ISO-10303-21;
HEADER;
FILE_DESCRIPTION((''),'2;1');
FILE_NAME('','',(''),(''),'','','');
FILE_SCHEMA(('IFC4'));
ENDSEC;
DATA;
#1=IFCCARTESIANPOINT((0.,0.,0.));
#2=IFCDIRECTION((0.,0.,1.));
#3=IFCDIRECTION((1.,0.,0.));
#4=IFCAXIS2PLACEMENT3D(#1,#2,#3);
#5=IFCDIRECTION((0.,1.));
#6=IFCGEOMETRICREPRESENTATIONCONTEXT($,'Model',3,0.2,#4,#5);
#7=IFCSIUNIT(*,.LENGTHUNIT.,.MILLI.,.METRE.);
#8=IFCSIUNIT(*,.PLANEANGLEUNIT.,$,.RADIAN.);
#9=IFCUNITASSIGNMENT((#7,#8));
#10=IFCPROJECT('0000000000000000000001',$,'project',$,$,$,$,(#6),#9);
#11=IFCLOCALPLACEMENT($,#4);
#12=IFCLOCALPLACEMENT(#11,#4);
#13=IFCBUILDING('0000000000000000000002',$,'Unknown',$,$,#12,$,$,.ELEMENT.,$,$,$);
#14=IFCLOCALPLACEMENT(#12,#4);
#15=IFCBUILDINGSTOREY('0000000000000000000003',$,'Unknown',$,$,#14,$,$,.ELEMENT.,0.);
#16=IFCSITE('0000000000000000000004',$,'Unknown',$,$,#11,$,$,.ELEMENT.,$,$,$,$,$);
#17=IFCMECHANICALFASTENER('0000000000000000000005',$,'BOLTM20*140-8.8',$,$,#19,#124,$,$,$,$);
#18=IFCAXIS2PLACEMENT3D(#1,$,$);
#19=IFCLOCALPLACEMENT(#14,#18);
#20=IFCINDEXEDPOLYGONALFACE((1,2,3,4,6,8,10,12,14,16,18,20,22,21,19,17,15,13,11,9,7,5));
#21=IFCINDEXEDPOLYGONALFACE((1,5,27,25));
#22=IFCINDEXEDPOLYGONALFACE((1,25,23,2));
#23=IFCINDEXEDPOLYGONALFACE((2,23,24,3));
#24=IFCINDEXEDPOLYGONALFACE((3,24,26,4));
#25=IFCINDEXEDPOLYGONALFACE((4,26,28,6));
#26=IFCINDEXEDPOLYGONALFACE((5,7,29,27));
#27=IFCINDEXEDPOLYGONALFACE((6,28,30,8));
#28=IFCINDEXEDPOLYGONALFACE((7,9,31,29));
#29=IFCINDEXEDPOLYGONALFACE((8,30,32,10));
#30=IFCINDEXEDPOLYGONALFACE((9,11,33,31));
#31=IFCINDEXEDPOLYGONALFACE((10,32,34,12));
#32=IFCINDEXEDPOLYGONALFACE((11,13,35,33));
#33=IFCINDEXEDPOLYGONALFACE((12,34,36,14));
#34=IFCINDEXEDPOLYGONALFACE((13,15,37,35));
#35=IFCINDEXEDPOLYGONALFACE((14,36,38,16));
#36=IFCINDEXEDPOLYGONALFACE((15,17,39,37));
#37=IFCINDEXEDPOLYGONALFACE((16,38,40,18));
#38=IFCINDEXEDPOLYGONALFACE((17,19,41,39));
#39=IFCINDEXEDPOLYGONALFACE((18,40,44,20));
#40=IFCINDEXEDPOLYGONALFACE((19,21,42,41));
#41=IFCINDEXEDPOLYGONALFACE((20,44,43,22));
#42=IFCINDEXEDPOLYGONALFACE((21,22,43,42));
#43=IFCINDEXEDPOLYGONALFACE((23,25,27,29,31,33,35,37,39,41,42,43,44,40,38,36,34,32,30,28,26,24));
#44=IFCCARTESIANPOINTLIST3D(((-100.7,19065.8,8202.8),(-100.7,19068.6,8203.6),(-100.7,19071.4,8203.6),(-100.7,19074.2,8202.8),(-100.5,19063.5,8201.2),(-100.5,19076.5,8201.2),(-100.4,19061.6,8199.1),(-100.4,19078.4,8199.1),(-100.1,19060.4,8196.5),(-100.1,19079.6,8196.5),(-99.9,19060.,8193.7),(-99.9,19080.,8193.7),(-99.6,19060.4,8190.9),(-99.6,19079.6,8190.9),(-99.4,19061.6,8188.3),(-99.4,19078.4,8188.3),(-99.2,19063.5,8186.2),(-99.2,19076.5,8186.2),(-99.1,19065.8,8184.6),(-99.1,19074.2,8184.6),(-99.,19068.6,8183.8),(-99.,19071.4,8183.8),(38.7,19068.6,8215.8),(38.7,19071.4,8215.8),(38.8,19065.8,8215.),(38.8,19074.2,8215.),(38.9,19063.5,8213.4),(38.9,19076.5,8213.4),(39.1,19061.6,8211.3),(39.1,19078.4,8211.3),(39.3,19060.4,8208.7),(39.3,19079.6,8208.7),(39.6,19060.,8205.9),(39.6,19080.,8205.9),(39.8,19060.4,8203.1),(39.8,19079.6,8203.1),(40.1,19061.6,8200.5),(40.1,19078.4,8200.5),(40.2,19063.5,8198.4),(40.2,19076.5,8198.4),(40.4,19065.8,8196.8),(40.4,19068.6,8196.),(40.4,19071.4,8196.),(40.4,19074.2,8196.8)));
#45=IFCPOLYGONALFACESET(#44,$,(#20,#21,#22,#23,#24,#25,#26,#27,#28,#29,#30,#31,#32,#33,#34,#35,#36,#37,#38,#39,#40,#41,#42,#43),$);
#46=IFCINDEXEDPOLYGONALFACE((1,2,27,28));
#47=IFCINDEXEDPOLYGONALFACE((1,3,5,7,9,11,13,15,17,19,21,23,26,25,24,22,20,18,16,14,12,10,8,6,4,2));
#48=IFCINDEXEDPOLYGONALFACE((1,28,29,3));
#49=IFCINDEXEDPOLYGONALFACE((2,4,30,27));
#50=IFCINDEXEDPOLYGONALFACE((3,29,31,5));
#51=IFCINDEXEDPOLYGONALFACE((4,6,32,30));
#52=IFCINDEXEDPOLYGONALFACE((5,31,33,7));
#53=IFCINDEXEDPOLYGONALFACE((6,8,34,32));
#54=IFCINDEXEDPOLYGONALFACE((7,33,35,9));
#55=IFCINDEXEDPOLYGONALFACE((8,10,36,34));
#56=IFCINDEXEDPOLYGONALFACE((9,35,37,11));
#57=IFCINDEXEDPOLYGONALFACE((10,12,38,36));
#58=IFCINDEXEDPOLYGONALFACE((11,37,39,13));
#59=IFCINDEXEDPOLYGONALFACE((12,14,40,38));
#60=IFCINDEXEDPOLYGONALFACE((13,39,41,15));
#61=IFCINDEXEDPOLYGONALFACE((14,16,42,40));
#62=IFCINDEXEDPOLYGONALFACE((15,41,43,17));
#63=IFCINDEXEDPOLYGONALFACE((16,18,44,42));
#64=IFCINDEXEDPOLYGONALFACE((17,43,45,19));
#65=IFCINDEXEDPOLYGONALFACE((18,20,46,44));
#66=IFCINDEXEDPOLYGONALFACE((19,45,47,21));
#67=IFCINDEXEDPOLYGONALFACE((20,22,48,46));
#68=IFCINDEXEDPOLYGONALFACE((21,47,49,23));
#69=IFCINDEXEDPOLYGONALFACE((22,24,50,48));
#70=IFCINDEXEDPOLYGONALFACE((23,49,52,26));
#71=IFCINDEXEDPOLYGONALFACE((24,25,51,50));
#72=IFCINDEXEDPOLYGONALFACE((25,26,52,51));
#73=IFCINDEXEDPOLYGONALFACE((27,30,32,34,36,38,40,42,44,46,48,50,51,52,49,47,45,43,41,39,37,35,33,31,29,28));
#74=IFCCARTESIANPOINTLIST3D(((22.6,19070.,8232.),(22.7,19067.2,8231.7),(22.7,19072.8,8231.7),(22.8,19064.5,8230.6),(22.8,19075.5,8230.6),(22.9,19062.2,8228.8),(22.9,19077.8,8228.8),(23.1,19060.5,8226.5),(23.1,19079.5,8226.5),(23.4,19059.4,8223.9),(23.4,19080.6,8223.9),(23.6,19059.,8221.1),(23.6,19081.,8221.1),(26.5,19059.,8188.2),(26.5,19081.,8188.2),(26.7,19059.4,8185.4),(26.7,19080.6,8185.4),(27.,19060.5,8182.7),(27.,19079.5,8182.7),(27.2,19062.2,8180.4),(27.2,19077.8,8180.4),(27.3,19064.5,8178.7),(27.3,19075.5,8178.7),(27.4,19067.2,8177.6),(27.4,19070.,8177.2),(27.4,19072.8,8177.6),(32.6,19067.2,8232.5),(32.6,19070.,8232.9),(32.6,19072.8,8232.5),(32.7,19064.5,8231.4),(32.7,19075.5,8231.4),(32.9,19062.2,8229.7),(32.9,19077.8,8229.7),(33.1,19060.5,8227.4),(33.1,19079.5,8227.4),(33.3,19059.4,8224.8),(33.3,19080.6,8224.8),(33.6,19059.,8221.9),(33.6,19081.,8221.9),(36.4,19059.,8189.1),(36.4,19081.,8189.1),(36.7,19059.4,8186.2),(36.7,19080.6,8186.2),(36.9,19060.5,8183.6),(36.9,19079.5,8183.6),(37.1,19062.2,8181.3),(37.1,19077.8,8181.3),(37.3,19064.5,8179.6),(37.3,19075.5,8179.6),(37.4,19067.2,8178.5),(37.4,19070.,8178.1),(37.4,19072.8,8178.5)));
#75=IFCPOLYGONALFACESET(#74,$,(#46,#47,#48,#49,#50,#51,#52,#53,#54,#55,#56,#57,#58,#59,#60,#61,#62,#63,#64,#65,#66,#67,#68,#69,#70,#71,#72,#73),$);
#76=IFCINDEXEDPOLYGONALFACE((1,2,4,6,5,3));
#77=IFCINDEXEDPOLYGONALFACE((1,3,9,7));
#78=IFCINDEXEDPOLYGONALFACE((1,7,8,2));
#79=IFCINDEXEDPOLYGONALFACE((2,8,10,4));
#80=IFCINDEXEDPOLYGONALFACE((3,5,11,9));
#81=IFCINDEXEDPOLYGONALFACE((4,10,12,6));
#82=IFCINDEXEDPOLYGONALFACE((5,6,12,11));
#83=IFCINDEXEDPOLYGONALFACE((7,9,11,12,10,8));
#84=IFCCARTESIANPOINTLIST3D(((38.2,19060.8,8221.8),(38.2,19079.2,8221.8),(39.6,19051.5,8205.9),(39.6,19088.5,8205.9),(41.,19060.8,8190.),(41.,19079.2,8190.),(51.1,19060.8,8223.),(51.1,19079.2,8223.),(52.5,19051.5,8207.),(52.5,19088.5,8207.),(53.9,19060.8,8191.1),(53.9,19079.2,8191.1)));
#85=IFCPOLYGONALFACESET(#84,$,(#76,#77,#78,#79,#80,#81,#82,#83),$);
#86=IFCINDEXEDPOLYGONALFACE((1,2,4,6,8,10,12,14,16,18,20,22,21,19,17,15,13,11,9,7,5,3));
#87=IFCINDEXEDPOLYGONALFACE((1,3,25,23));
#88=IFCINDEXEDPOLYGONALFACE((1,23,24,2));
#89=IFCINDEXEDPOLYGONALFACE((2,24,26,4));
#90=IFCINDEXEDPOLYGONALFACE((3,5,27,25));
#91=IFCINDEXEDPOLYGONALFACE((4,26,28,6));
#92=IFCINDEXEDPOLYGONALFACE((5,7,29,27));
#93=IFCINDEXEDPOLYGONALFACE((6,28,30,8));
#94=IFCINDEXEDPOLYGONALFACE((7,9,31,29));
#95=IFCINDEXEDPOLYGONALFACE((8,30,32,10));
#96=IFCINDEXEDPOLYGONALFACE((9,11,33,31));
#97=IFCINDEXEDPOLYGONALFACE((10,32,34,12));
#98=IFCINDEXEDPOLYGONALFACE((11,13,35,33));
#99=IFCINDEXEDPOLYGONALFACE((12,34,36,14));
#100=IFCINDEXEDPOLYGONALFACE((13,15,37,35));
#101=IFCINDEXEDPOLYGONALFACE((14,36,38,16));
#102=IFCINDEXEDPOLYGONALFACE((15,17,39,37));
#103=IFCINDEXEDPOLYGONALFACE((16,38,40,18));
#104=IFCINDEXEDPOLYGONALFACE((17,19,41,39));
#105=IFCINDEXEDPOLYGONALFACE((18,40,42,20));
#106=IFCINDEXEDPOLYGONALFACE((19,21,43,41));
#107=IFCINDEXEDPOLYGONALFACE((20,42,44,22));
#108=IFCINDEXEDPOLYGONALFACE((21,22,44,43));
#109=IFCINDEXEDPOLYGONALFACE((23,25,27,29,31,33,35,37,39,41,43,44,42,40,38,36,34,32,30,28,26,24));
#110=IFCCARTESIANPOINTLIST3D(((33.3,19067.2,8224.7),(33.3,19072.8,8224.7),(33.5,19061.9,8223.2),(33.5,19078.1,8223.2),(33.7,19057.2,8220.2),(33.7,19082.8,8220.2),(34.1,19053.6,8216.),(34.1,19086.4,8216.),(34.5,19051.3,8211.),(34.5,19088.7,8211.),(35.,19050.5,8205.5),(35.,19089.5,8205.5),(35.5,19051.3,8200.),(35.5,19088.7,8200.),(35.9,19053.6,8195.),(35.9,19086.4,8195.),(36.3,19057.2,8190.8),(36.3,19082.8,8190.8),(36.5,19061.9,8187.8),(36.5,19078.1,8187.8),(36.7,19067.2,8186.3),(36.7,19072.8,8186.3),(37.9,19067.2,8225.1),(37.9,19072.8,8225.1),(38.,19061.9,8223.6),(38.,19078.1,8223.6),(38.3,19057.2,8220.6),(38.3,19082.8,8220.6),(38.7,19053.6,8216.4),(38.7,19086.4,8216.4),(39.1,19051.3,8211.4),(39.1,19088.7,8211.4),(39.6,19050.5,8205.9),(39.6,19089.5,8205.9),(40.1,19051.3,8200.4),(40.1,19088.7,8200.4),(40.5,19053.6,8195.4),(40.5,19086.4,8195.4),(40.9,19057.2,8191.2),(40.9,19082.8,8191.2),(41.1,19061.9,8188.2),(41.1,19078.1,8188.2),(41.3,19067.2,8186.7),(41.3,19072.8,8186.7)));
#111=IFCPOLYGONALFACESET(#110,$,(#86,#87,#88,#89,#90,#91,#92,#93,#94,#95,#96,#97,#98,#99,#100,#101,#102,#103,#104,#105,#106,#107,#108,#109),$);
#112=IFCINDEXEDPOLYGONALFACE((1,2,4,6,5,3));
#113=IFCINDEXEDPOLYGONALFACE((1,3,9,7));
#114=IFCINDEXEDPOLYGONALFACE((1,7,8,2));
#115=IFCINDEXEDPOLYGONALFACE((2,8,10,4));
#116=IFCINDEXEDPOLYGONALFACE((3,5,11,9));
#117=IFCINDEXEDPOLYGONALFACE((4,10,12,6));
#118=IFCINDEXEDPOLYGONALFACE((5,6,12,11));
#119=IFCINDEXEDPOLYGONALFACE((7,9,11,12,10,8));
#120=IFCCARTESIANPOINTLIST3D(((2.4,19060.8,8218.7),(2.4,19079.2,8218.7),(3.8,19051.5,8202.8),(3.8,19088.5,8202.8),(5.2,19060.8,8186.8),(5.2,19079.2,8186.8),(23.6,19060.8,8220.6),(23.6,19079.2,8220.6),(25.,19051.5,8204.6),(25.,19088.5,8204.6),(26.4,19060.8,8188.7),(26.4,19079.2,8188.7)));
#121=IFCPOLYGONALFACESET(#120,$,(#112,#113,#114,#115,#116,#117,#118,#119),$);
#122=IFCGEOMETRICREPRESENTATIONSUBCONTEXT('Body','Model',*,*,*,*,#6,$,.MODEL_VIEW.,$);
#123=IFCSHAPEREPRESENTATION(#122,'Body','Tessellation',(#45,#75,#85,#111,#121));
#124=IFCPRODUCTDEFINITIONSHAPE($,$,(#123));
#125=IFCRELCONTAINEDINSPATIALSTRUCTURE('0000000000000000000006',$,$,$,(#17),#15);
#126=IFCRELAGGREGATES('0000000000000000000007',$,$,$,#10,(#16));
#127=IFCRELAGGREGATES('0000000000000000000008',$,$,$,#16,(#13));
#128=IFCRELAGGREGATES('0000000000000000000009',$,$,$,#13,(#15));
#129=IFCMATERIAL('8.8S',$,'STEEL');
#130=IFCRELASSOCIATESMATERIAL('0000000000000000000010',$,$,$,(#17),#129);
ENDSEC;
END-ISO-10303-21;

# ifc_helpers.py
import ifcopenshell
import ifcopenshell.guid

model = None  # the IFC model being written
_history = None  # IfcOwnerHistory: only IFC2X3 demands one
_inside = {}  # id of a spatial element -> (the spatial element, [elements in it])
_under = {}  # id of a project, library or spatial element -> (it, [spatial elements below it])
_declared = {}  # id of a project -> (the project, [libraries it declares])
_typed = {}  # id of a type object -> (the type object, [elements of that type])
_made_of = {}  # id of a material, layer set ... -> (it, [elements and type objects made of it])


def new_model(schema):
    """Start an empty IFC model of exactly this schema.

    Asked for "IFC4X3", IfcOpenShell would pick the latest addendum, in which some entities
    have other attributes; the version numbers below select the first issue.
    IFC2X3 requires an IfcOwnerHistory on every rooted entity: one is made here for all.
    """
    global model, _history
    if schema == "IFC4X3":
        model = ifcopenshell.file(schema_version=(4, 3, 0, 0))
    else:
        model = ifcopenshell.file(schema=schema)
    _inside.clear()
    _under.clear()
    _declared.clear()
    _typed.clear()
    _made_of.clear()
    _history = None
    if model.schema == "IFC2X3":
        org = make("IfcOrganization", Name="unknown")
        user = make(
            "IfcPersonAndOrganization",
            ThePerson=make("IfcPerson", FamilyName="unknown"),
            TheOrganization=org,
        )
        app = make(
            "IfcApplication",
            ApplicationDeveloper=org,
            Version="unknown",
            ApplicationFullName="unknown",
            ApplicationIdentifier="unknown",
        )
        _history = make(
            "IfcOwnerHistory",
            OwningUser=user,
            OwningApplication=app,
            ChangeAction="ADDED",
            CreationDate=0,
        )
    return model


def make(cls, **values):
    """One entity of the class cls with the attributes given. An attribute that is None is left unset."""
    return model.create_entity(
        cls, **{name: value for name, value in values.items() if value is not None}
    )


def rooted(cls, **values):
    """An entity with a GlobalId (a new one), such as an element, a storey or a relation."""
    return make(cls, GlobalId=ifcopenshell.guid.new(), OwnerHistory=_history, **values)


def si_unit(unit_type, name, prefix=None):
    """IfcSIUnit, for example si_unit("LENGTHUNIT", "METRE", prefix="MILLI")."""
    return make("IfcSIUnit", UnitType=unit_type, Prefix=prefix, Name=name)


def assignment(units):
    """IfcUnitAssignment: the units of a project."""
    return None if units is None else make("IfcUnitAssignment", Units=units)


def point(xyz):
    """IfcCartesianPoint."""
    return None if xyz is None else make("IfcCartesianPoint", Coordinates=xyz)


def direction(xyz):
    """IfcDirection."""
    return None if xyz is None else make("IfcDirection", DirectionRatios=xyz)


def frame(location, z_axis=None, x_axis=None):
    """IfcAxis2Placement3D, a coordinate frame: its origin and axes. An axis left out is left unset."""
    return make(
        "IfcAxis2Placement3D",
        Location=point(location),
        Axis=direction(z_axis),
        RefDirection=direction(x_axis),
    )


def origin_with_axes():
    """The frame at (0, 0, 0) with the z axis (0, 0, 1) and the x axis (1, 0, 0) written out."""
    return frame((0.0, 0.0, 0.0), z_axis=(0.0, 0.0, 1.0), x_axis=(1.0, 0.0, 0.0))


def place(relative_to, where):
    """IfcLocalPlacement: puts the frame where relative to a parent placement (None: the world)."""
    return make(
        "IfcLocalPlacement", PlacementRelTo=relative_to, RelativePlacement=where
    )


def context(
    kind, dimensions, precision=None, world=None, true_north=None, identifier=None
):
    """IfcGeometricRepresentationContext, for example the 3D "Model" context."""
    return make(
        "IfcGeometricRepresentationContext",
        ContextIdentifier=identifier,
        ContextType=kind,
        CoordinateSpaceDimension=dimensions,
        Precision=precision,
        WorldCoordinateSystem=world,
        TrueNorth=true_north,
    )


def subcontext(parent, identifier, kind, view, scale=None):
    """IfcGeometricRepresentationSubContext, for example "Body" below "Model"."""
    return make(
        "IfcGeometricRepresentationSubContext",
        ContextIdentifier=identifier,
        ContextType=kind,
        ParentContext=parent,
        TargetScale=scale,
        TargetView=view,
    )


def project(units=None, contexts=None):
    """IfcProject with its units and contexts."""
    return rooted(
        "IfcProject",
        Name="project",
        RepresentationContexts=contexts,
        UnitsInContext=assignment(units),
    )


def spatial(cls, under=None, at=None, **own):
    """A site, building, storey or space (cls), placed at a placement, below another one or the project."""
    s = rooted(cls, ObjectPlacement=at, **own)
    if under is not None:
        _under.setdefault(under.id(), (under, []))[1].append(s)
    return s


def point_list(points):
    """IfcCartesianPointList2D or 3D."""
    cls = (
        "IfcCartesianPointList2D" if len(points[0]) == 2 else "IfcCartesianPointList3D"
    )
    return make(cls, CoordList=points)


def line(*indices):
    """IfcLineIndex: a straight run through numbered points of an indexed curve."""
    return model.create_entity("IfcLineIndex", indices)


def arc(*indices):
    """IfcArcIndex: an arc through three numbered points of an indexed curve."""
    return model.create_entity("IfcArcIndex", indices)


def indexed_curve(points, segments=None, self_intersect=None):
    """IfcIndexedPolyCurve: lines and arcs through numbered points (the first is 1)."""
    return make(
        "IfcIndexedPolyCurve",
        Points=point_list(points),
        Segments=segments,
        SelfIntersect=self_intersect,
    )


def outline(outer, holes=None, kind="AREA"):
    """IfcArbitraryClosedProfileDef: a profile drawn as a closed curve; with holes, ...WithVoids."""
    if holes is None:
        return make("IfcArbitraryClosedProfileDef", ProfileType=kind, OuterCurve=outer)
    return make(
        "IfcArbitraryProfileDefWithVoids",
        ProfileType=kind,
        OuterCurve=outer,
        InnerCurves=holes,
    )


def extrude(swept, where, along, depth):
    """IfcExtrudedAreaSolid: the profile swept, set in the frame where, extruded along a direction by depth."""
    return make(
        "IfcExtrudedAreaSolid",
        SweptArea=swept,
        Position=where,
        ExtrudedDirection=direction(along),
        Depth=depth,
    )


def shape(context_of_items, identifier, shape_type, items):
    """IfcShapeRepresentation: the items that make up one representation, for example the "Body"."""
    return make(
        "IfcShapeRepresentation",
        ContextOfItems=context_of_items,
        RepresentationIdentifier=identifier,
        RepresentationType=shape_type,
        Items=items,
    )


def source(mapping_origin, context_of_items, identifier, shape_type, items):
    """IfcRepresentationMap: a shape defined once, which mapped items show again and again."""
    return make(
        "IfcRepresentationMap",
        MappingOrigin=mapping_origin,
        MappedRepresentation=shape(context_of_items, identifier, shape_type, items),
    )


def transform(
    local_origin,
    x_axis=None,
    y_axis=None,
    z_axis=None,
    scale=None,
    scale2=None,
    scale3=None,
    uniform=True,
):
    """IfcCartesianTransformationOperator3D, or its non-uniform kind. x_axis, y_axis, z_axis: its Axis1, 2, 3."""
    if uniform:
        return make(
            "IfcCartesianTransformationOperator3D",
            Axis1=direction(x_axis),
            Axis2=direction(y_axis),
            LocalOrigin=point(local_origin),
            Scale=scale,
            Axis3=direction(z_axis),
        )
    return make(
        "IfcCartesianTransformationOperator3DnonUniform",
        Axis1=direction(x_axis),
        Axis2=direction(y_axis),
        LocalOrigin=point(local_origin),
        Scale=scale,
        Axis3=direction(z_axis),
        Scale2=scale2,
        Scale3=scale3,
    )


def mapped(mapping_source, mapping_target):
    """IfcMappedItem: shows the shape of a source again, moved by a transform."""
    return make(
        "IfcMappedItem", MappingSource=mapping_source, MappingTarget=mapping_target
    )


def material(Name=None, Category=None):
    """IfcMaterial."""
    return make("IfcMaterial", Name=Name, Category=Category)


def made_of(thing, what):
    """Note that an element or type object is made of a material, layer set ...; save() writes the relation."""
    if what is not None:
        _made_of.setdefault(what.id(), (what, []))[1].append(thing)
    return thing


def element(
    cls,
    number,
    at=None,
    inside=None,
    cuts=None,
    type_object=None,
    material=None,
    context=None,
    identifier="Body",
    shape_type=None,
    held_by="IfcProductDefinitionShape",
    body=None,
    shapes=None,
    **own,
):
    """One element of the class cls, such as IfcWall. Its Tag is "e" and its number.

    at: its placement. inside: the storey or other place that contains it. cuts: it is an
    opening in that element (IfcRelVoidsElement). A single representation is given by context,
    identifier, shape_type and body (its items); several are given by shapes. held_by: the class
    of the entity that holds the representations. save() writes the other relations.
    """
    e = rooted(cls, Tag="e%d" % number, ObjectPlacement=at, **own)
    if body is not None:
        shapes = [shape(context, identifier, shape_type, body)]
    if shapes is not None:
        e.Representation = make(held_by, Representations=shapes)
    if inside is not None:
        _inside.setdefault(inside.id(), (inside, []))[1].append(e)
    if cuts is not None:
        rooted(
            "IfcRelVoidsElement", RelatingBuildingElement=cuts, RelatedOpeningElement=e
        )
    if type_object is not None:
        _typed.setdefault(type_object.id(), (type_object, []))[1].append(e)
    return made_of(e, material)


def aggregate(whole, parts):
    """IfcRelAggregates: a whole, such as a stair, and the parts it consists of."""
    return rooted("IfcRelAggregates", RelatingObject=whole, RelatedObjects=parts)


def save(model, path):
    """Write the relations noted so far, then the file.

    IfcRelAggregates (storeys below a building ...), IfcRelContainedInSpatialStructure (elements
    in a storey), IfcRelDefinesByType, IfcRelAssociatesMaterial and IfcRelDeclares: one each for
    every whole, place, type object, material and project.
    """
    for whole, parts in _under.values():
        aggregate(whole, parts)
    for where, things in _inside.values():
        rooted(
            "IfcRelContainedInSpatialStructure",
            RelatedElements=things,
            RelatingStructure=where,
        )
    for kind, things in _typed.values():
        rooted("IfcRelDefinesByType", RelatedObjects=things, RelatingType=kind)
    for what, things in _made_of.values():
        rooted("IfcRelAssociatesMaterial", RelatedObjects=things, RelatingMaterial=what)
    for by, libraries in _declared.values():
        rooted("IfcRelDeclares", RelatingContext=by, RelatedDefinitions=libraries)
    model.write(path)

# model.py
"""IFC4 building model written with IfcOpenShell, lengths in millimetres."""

from ifc_helpers import new_model, si_unit, direction, frame, origin_with_axes, place, context, subcontext, project, spatial, line, arc, indexed_curve, outline, extrude, source, transform, mapped, material, element, save


model = new_model("IFC4")

# Units and contexts
model_context = context("Model", 3, precision=0.2, world=origin_with_axes(), true_north=direction((0.0, 1.0)))
body_context = subcontext(model_context, "Body", "Model", "MODEL_VIEW")
ifc_project = project(units=[si_unit("LENGTHUNIT", "METRE", prefix="MILLI"), si_unit("PLANEANGLEUNIT", "RADIAN")], contexts=[model_context])

# Site, building, storey
site_placement = place(None, origin_with_axes())
site = spatial("IfcSite", under=ifc_project, at=site_placement, Name="Unknown", CompositionType="ELEMENT")
building_placement = place(site_placement, origin_with_axes())
building = spatial("IfcBuilding", under=site, at=building_placement, Name="Unknown", CompositionType="ELEMENT")
storey_placement = place(building_placement, origin_with_axes())
storey = spatial("IfcBuildingStorey", under=building, at=storey_placement, Name="Unknown", CompositionType="ELEMENT", Elevation=0.0)

# Mechanical fastener
ifc_material_1 = material(Name="8.8S", Category="STEEL")
shared_shape_1 = source(origin_with_axes(), body_context, "Body", "SweptSolid", [
    extrude(outline(indexed_curve([(10.0, 0.0), (0.0, 10.0), (-10.0, 0.0), (0.0, -10.0)], segments=[arc(1, 2, 3), arc(3, 4, 1)])), frame((0.0, 0.0, 4.6), z_axis=(0.0, 0.0, -1.0), x_axis=(0.0, 1.0, 0.0)), (0.0, 0.0, 1.0), 140.0),
    extrude(outline(indexed_curve([(0.0, 27.5), (7.8, 24.3), (11.0, 16.5), (11.0, -16.5), (7.8, -24.3), (0.0, -27.5), (-1.0, -27.5), (-11.0, -16.5), (-11.0, 16.5), (-7.8, 24.3)], segments=[arc(1, 2, 3), line(3, 4), arc(4, 5, 6), arc(6, 7, 8), line(8, 9), arc(9, 10, 1)])), frame((0.0, 0.0, 0.0), z_axis=(0.0, 0.0, -1.0), x_axis=(0.0, 1.0, 0.0)), (0.0, 0.0, 1.0), 10.0),
    extrude(outline(indexed_curve([(18.5, 0.0), (9.2, 16.0), (-9.2, 16.0), (-18.5, 0.0), (-9.2, -16.0), (9.2, -16.0)], segments=[line(1, 2, 3, 4, 5, 6, 1)])), frame((0.0, 0.0, 17.6), z_axis=(0.0, 0.0, -1.0), x_axis=(0.0, 1.0, 0.0)), (0.0, 0.0, 1.0), 13.0),
    extrude(outline(indexed_curve([(19.5, 0.0), (0.0, 19.5), (-19.5, 0.0), (0.0, -19.5)], segments=[arc(1, 2, 3), arc(3, 4, 1)])), frame((0.0, 0.0, 4.6), z_axis=(0.0, 0.0, -1.0), x_axis=(0.0, 1.0, 0.0)), (0.0, 0.0, 1.0), 4.6),
    extrude(outline(indexed_curve([(18.5, 0.0), (9.2, 16.0), (-9.2, 16.0), (-18.5, 0.0), (-9.2, -16.0), (9.2, -16.0)], segments=[line(1, 2, 3, 4, 5, 6, 1)])), frame((0.0, 0.0, -10.0), z_axis=(0.0, 0.0, -1.0), x_axis=(0.0, 1.0, 0.0)), (0.0, 0.0, 1.0), 21.3),
])
mechanical_fastener_1_placement = place(storey_placement, frame((35.0, 19070.0, 8205.5), z_axis=(0.996195, 0.0, 0.087156), x_axis=(0.087156, 0.0, -0.996195)))
element("IfcMechanicalFastener", 1, at=mechanical_fastener_1_placement, inside=storey, material=ifc_material_1, Name="BOLTM20*140-8.8", context=body_context, shape_type="MappedRepresentation", body=[
    mapped(shared_shape_1, transform((0.0, 0.0, 0.0))),
])

save(model, "model.ifc")
